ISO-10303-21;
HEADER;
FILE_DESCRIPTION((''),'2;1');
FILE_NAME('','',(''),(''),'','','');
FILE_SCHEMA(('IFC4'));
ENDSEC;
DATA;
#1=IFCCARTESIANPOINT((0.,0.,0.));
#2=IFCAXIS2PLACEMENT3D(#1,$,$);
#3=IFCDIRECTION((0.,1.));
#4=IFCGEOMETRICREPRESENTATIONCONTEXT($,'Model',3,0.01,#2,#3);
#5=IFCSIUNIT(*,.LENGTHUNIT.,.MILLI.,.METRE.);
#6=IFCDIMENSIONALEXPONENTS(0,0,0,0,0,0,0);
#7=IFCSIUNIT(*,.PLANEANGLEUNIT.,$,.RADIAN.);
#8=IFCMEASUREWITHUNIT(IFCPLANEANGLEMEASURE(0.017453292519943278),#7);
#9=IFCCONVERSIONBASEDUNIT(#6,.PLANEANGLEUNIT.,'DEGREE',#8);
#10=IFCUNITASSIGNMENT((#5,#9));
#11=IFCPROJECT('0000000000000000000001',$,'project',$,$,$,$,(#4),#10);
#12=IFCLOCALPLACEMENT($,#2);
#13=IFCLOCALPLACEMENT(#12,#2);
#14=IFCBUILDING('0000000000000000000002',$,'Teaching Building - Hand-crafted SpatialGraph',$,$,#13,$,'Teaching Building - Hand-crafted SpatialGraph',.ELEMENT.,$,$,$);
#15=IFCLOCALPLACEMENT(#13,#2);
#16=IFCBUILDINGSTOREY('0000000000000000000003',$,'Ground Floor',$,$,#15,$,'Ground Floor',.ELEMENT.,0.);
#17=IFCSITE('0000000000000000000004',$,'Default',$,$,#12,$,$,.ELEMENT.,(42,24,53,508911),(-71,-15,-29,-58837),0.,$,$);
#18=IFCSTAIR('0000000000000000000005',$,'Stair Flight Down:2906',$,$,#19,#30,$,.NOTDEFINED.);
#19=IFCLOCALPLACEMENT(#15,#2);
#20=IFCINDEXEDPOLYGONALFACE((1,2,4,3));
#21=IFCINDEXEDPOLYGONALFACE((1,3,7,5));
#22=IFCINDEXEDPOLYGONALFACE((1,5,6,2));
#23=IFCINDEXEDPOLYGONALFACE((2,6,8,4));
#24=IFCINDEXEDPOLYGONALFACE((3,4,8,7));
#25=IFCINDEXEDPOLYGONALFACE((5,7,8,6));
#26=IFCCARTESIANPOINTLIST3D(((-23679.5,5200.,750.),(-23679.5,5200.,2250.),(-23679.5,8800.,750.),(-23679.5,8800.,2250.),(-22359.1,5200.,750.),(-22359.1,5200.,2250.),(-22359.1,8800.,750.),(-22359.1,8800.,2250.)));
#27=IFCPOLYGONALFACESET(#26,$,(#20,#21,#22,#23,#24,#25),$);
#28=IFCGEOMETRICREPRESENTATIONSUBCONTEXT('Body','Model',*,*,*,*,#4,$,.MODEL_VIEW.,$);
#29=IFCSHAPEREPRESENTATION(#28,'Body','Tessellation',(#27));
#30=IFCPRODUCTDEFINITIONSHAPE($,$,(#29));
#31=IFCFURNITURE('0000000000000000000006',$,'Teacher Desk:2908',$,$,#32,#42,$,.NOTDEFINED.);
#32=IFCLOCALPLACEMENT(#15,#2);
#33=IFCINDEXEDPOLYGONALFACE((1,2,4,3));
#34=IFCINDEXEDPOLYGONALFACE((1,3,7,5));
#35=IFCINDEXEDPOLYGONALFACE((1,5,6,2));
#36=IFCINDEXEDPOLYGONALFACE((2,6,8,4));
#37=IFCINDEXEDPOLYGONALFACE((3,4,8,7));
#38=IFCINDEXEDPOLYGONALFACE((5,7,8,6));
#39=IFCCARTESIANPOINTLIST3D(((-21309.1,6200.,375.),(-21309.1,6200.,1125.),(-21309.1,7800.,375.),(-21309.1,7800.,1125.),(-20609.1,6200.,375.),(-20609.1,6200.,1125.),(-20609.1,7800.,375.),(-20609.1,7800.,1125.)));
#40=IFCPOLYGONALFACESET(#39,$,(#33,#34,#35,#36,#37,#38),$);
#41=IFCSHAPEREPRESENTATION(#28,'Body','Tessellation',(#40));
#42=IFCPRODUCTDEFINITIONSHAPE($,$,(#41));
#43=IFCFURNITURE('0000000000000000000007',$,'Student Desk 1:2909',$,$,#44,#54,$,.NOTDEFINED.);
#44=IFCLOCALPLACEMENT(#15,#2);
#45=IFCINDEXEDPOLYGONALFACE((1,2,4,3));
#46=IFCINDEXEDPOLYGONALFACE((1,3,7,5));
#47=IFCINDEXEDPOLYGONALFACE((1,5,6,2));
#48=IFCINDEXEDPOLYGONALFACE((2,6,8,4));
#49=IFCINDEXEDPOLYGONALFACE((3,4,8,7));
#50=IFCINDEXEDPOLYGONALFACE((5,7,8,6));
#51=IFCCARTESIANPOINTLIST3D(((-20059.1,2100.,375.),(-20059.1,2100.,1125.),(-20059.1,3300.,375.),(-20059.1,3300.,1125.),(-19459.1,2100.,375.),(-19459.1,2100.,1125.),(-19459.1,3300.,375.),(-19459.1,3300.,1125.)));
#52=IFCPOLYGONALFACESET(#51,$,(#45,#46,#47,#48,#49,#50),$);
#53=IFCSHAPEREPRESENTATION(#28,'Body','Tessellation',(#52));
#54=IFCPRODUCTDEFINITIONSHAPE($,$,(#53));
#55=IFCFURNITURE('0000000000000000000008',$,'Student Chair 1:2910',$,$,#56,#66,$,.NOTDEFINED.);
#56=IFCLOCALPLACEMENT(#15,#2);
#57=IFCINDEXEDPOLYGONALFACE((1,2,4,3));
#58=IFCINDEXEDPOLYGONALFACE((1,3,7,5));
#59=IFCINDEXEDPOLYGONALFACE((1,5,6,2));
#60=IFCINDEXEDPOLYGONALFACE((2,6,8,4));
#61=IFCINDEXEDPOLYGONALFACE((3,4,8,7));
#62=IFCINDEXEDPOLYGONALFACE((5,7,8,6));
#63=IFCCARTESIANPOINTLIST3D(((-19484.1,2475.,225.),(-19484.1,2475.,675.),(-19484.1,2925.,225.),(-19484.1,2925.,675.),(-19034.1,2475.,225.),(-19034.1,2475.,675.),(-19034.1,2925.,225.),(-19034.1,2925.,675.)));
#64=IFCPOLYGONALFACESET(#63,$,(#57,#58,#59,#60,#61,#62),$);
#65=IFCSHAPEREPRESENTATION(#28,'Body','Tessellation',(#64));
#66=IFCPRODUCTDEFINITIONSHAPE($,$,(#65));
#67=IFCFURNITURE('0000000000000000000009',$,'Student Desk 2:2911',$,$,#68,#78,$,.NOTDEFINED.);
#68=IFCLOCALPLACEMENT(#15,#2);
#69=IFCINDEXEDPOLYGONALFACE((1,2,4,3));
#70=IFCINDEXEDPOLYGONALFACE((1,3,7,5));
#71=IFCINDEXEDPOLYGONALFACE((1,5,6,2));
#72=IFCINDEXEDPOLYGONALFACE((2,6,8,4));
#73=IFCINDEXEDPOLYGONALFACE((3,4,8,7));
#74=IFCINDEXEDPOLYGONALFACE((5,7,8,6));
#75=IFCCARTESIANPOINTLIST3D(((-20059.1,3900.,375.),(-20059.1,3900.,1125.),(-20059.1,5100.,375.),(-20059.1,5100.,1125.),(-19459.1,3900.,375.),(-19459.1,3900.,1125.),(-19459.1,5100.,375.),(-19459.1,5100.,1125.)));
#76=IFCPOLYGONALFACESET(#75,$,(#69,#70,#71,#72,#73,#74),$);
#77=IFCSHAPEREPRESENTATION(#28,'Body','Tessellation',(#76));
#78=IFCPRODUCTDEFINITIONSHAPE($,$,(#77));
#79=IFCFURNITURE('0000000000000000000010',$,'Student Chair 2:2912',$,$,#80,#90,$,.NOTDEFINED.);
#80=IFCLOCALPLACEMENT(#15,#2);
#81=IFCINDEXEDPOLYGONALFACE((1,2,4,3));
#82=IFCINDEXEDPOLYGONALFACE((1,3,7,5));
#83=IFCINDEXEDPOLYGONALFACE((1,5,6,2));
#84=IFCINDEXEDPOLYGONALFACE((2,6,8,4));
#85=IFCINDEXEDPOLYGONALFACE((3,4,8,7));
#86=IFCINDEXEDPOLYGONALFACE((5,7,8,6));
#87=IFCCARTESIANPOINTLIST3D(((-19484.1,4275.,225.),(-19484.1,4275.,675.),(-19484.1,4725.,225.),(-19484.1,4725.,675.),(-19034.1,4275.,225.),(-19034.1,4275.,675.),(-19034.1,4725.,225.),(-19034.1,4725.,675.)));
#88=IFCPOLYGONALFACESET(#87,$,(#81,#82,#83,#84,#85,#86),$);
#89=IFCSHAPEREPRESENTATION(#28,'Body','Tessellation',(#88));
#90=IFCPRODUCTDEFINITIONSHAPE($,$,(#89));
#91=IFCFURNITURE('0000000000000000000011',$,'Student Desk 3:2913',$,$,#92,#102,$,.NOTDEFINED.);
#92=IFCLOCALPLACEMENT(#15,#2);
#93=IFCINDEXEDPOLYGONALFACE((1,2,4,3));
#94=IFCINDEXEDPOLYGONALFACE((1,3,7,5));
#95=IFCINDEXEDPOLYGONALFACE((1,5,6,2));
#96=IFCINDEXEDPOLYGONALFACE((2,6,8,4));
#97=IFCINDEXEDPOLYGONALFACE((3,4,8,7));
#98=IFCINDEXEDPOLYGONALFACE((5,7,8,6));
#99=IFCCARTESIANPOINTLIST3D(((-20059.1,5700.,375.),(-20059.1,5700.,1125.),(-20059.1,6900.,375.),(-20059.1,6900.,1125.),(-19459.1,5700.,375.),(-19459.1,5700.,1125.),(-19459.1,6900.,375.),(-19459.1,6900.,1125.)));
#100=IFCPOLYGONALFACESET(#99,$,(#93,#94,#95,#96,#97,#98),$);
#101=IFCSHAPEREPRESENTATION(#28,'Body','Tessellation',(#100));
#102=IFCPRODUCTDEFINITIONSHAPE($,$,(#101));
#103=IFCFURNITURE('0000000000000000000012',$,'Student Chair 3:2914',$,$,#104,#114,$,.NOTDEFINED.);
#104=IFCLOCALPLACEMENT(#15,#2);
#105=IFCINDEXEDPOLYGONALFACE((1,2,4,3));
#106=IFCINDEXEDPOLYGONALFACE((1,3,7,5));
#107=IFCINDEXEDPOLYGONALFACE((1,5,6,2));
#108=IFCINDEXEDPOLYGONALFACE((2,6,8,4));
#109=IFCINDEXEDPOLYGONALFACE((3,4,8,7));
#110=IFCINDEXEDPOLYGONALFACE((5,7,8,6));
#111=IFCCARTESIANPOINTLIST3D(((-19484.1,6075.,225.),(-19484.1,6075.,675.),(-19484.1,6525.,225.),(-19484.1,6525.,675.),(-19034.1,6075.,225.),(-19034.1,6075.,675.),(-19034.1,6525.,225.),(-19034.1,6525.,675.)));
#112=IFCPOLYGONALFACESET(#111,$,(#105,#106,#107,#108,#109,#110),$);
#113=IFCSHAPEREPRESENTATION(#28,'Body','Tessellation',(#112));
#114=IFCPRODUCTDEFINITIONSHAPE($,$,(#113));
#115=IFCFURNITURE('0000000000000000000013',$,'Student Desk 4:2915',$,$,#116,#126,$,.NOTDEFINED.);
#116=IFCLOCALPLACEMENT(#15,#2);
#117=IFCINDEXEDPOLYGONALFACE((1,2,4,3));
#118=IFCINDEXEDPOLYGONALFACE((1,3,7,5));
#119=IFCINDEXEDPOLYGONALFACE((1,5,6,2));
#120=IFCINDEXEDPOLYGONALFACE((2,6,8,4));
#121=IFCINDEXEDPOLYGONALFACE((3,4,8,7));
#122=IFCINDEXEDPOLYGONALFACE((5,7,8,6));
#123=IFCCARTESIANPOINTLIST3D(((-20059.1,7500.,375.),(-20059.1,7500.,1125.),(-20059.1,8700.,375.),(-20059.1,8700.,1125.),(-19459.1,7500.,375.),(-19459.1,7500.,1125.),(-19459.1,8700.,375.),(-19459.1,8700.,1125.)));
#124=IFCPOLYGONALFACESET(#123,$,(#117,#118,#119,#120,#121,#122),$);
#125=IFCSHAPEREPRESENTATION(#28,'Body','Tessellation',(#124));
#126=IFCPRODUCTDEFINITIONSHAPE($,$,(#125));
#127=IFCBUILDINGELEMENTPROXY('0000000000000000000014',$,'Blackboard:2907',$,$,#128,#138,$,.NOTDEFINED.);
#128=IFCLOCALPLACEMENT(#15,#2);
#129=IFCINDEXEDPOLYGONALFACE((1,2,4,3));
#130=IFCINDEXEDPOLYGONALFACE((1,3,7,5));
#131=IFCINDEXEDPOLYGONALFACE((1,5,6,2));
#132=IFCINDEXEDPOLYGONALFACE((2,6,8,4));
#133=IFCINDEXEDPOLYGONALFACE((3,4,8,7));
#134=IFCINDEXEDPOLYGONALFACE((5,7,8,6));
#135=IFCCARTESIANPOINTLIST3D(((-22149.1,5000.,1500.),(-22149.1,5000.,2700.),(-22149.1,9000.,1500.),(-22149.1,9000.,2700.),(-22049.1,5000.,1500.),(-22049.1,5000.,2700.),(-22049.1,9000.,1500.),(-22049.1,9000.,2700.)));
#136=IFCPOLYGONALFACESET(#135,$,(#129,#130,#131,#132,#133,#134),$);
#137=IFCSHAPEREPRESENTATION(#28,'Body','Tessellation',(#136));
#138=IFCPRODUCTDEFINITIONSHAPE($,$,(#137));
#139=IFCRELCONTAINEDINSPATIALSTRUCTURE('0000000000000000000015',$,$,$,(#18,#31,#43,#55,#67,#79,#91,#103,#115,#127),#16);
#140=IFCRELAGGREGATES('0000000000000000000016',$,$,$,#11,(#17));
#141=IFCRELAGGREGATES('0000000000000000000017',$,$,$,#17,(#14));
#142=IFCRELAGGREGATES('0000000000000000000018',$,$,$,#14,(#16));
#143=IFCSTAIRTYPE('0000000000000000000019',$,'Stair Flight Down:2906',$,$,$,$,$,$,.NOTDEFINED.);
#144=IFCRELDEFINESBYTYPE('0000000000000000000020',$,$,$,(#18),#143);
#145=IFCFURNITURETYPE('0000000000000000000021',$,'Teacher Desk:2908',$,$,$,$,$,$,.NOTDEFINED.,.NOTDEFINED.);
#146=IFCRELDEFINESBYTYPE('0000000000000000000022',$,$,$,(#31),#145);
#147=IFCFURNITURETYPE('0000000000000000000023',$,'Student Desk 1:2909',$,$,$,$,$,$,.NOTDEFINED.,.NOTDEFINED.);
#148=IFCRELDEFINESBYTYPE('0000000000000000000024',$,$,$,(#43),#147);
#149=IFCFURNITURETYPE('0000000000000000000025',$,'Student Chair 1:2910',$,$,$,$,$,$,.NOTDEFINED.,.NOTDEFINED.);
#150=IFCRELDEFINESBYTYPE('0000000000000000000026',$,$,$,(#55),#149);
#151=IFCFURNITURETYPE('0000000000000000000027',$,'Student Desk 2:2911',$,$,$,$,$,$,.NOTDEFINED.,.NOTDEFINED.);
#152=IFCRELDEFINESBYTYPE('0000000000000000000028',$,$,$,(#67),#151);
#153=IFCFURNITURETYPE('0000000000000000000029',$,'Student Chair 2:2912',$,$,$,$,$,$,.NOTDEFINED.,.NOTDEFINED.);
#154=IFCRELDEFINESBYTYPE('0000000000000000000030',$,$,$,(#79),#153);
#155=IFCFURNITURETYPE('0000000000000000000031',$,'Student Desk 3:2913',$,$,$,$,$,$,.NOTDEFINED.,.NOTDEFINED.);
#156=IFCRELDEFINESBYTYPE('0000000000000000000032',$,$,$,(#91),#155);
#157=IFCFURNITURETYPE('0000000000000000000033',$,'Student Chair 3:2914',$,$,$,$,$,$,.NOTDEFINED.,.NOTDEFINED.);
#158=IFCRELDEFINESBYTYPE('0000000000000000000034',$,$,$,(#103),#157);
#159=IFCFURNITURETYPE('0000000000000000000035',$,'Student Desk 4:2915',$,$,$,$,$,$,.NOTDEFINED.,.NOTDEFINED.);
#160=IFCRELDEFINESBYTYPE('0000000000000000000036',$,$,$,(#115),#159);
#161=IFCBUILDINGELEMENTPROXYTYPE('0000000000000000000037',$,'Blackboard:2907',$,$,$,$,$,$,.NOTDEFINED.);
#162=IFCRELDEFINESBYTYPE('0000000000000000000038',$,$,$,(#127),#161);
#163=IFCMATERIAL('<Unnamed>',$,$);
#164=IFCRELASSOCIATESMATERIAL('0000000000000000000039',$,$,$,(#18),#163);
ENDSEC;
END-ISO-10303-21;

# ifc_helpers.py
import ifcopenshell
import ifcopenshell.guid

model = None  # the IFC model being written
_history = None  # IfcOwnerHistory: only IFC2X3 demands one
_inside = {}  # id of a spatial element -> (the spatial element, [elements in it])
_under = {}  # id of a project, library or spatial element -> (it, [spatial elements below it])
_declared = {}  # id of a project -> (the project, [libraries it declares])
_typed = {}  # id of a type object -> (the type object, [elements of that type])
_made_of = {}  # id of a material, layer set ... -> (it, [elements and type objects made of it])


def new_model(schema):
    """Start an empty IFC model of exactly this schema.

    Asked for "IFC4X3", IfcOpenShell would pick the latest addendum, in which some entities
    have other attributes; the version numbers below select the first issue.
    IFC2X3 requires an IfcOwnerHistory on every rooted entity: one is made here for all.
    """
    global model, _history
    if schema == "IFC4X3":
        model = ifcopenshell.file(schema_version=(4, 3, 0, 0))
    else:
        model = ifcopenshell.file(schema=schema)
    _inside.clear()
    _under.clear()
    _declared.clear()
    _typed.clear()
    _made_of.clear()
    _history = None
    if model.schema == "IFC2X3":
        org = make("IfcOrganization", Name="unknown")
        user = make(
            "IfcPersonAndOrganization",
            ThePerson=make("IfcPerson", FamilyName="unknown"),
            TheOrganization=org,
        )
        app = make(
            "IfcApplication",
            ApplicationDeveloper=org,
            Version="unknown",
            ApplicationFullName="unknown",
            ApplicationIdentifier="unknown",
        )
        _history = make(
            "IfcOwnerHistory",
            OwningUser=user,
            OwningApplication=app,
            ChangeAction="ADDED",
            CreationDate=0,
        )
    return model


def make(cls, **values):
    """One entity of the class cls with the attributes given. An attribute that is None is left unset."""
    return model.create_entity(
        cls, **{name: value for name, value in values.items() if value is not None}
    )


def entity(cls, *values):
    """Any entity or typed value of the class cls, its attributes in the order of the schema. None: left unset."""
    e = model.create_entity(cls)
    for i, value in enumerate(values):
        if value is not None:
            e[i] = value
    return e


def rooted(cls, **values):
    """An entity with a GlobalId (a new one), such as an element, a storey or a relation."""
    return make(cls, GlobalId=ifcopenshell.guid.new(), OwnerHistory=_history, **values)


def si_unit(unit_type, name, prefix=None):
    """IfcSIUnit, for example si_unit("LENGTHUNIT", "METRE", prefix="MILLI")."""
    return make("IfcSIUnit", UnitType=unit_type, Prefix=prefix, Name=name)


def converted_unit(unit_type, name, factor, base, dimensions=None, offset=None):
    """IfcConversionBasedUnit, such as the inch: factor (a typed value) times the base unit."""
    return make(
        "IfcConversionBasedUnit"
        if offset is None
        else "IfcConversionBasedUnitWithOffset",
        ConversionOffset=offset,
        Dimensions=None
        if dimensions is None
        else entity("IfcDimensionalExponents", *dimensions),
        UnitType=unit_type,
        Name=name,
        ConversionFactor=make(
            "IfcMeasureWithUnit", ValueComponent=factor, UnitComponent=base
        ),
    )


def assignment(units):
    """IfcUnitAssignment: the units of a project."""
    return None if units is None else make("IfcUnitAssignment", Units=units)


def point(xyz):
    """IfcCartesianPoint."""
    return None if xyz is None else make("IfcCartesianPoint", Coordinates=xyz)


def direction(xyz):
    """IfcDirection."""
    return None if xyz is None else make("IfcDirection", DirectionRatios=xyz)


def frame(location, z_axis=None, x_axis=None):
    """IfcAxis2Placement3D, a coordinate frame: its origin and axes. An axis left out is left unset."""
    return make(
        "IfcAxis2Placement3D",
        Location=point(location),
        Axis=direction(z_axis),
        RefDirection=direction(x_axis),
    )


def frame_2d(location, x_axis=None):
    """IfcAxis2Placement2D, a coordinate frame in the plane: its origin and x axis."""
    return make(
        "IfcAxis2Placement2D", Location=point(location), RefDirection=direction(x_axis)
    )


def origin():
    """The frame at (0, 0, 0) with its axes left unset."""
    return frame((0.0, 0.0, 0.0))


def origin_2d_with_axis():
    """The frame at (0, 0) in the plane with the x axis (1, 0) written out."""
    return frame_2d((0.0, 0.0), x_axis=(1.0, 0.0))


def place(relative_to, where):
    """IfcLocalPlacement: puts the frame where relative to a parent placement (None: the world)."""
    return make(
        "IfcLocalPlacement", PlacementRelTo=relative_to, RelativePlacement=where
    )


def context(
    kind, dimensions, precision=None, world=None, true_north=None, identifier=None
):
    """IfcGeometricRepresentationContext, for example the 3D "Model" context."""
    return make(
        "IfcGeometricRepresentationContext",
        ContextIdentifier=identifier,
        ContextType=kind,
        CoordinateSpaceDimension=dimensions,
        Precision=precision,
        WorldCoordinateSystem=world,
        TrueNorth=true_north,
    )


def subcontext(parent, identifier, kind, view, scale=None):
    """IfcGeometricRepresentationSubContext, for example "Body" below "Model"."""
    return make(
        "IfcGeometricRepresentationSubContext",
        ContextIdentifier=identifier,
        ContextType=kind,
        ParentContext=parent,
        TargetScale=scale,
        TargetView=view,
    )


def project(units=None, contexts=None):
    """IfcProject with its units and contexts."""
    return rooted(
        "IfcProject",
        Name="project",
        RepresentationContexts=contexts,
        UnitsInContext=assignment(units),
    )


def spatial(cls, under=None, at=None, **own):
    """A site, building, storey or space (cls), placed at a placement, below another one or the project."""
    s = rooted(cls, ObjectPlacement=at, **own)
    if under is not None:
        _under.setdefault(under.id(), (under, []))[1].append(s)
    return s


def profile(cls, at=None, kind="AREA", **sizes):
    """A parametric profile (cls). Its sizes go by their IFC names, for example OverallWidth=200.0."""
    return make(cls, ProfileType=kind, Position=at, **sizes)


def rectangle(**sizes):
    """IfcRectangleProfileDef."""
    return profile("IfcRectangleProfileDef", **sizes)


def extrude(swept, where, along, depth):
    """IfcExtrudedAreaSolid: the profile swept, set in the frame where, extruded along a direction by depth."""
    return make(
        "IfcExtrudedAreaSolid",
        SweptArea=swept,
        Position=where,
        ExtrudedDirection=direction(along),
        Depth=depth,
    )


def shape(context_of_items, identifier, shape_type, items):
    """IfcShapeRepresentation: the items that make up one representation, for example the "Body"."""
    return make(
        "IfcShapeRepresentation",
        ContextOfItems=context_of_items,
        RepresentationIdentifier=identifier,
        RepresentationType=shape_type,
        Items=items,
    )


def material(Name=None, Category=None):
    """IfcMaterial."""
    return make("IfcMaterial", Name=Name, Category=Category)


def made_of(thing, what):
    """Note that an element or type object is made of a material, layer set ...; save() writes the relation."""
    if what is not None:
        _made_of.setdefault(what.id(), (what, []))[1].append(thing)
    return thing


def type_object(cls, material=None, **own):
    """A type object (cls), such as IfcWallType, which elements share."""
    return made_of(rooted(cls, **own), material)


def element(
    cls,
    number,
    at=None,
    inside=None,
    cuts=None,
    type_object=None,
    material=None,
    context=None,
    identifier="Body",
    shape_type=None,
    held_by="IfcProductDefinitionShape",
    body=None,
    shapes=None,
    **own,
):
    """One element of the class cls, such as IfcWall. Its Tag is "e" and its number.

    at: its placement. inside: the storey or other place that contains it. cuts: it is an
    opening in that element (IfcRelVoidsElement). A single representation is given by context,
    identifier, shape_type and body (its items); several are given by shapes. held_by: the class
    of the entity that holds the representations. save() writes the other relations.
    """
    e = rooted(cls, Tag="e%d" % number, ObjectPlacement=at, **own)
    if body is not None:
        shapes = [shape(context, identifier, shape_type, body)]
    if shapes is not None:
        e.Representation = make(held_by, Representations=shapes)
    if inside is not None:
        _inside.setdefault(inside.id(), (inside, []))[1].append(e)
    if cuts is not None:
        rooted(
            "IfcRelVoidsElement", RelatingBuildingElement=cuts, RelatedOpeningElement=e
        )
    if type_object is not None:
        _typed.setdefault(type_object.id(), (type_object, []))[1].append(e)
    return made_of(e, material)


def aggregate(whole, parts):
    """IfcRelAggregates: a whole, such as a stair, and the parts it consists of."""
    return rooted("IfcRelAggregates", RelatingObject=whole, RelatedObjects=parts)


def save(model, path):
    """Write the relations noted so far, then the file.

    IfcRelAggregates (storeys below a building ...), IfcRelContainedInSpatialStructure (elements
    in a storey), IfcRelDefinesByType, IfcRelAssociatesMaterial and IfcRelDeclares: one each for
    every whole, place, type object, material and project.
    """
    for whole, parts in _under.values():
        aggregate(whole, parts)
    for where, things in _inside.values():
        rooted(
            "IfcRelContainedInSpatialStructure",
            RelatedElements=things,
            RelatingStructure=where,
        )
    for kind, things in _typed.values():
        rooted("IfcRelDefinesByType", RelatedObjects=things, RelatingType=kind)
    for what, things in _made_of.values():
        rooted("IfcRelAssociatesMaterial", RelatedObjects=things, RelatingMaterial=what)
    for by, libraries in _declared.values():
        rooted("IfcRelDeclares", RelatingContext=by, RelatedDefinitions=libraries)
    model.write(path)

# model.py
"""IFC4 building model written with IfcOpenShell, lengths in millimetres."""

from ifc_helpers import new_model, entity, si_unit, converted_unit, direction, frame, frame_2d, origin, origin_2d_with_axis, place, context, subcontext, project, spatial, rectangle, extrude, material, type_object, element, save


model = new_model("IFC4")

# Units and contexts
model_context = context("Model", 3, precision=0.01, world=origin(), true_north=direction((0.0, 1.0)))
body_context = subcontext(model_context, "Body", "Model", "MODEL_VIEW")
ifc_project = project(units=[si_unit("LENGTHUNIT", "METRE", prefix="MILLI"), converted_unit("PLANEANGLEUNIT", "DEGREE", entity("IfcPlaneAngleMeasure", 0.017453292519943278), si_unit("PLANEANGLEUNIT", "RADIAN"), dimensions=[0, 0, 0, 0, 0, 0, 0])], contexts=[model_context])

# Site, building, storey
site_placement = place(None, origin())
site = spatial("IfcSite", under=ifc_project, at=site_placement, Name="Default", CompositionType="ELEMENT", RefLatitude=(42, 24, 53, 508911), RefLongitude=(-71, -15, -29, -58837), RefElevation=0.0)
building_placement = place(site_placement, origin())
building = spatial("IfcBuilding", under=site, at=building_placement, Name="Teaching Building - Hand-crafted SpatialGraph", LongName="Teaching Building - Hand-crafted SpatialGraph", CompositionType="ELEMENT")
storey_placement = place(building_placement, origin())
storey = spatial("IfcBuildingStorey", under=building, at=storey_placement, Name="Ground Floor", LongName="Ground Floor", CompositionType="ELEMENT", Elevation=0.0)

# Shared definitions
ifc_material_1 = material(Name="<Unnamed>")

# Stair
stair_type_1 = type_object("IfcStairType", Name="Stair Flight Down:2906", PredefinedType="NOTDEFINED")
stair_1_placement = place(storey_placement, origin())
element("IfcStair", 1, at=stair_1_placement, inside=storey, type_object=stair_type_1, material=ifc_material_1, Name="Stair Flight Down:2906", PredefinedType="NOTDEFINED", context=body_context, shape_type="SweptSolid", body=[
    extrude(rectangle(XDim=1320.5, YDim=3600.0, at=origin_2d_with_axis()), frame((-23019.3, 7000.0, 750.0)), (0.0, 0.0, 1.0), 1500.0),
])

# Furniture
furniture_type_1 = type_object("IfcFurnitureType", Name="Teacher Desk:2908", PredefinedType="NOTDEFINED")
furniture_1_placement = place(storey_placement, origin())
element("IfcFurniture", 2, at=furniture_1_placement, inside=storey, type_object=furniture_type_1, Name="Teacher Desk:2908", PredefinedType="NOTDEFINED", context=body_context, shape_type="SweptSolid", body=[
    extrude(rectangle(XDim=1600.0, YDim=700.0, at=origin_2d_with_axis()), frame((-20959.1, 7000.0, 375.0), z_axis=(0.0, 0.0, 1.0), x_axis=(0.0, 1.0, 0.0)), (0.0, 0.0, 1.0), 750.0),
])
furniture_type_2 = type_object("IfcFurnitureType", Name="Student Desk 1:2909", PredefinedType="NOTDEFINED")
furniture_2_placement = place(storey_placement, origin())
element("IfcFurniture", 3, at=furniture_2_placement, inside=storey, type_object=furniture_type_2, Name="Student Desk 1:2909", PredefinedType="NOTDEFINED", context=body_context, shape_type="SweptSolid", body=[
    extrude(rectangle(XDim=1200.0, YDim=600.0, at=frame_2d((0.0, 0.0), x_axis=(1.0, 0.0))), frame((-19759.1, 2700.0, 375.0), z_axis=(0.0, 0.0, 1.0), x_axis=(0.0, 1.0, 0.0)), (0.0, 0.0, 1.0), 750.0),
])
furniture_type_3 = type_object("IfcFurnitureType", Name="Student Chair 1:2910", PredefinedType="NOTDEFINED")
furniture_3_placement = place(storey_placement, origin())
element("IfcFurniture", 4, at=furniture_3_placement, inside=storey, type_object=furniture_type_3, Name="Student Chair 1:2910", PredefinedType="NOTDEFINED", context=body_context, shape_type="SweptSolid", body=[
    extrude(rectangle(XDim=450.0, YDim=450.0, at=origin_2d_with_axis()), frame((-19259.1, 2700.0, 225.0)), (0.0, 0.0, 1.0), 450.0),
])
furniture_type_4 = type_object("IfcFurnitureType", Name="Student Desk 2:2911", PredefinedType="NOTDEFINED")
furniture_4_placement = place(storey_placement, origin())
element("IfcFurniture", 5, at=furniture_4_placement, inside=storey, type_object=furniture_type_4, Name="Student Desk 2:2911", PredefinedType="NOTDEFINED", context=body_context, shape_type="SweptSolid", body=[
    extrude(rectangle(XDim=1200.0, YDim=600.0, at=frame_2d((0.0, 0.0), x_axis=(1.0, 0.0))), frame((-19759.1, 4500.0, 375.0), z_axis=(0.0, 0.0, 1.0), x_axis=(0.0, 1.0, 0.0)), (0.0, 0.0, 1.0), 750.0),
])
furniture_type_5 = type_object("IfcFurnitureType", Name="Student Chair 2:2912", PredefinedType="NOTDEFINED")
furniture_5_placement = place(storey_placement, origin())
element("IfcFurniture", 6, at=furniture_5_placement, inside=storey, type_object=furniture_type_5, Name="Student Chair 2:2912", PredefinedType="NOTDEFINED", context=body_context, shape_type="SweptSolid", body=[
    extrude(rectangle(XDim=450.0, YDim=450.0, at=origin_2d_with_axis()), frame((-19259.1, 4500.0, 225.0)), (0.0, 0.0, 1.0), 450.0),
])
furniture_type_6 = type_object("IfcFurnitureType", Name="Student Desk 3:2913", PredefinedType="NOTDEFINED")
furniture_6_placement = place(storey_placement, origin())
element("IfcFurniture", 7, at=furniture_6_placement, inside=storey, type_object=furniture_type_6, Name="Student Desk 3:2913", PredefinedType="NOTDEFINED", context=body_context, shape_type="SweptSolid", body=[
    extrude(rectangle(XDim=1200.0, YDim=600.0, at=frame_2d((0.0, 0.0), x_axis=(1.0, 0.0))), frame((-19759.1, 6300.0, 375.0), z_axis=(0.0, 0.0, 1.0), x_axis=(0.0, 1.0, 0.0)), (0.0, 0.0, 1.0), 750.0),
])
furniture_type_7 = type_object("IfcFurnitureType", Name="Student Chair 3:2914", PredefinedType="NOTDEFINED")
furniture_7_placement = place(storey_placement, origin())
element("IfcFurniture", 8, at=furniture_7_placement, inside=storey, type_object=furniture_type_7, Name="Student Chair 3:2914", PredefinedType="NOTDEFINED", context=body_context, shape_type="SweptSolid", body=[
    extrude(rectangle(XDim=450.0, YDim=450.0, at=origin_2d_with_axis()), frame((-19259.1, 6300.0, 225.0)), (0.0, 0.0, 1.0), 450.0),
])
furniture_type_8 = type_object("IfcFurnitureType", Name="Student Desk 4:2915", PredefinedType="NOTDEFINED")
furniture_8_placement = place(storey_placement, origin())
element("IfcFurniture", 9, at=furniture_8_placement, inside=storey, type_object=furniture_type_8, Name="Student Desk 4:2915", PredefinedType="NOTDEFINED", context=body_context, shape_type="SweptSolid", body=[
    extrude(rectangle(XDim=1200.0, YDim=600.0, at=frame_2d((0.0, 0.0), x_axis=(1.0, 0.0))), frame((-19759.1, 8100.0, 375.0), z_axis=(0.0, 0.0, 1.0), x_axis=(0.0, 1.0, 0.0)), (0.0, 0.0, 1.0), 750.0),
])

# Building element proxy
building_element_proxy_type = type_object("IfcBuildingElementProxyType", Name="Blackboard:2907", PredefinedType="NOTDEFINED")
proxy_placement = place(storey_placement, origin())
element("IfcBuildingElementProxy", 10, at=proxy_placement, inside=storey, type_object=building_element_proxy_type, Name="Blackboard:2907", PredefinedType="NOTDEFINED", context=body_context, shape_type="SweptSolid", body=[
    extrude(rectangle(XDim=100.0, YDim=4000.0, at=origin_2d_with_axis()), frame((-22099.1, 7000.0, 1500.0)), (0.0, 0.0, 1.0), 1200.0),
])

save(model, "model.ifc")
